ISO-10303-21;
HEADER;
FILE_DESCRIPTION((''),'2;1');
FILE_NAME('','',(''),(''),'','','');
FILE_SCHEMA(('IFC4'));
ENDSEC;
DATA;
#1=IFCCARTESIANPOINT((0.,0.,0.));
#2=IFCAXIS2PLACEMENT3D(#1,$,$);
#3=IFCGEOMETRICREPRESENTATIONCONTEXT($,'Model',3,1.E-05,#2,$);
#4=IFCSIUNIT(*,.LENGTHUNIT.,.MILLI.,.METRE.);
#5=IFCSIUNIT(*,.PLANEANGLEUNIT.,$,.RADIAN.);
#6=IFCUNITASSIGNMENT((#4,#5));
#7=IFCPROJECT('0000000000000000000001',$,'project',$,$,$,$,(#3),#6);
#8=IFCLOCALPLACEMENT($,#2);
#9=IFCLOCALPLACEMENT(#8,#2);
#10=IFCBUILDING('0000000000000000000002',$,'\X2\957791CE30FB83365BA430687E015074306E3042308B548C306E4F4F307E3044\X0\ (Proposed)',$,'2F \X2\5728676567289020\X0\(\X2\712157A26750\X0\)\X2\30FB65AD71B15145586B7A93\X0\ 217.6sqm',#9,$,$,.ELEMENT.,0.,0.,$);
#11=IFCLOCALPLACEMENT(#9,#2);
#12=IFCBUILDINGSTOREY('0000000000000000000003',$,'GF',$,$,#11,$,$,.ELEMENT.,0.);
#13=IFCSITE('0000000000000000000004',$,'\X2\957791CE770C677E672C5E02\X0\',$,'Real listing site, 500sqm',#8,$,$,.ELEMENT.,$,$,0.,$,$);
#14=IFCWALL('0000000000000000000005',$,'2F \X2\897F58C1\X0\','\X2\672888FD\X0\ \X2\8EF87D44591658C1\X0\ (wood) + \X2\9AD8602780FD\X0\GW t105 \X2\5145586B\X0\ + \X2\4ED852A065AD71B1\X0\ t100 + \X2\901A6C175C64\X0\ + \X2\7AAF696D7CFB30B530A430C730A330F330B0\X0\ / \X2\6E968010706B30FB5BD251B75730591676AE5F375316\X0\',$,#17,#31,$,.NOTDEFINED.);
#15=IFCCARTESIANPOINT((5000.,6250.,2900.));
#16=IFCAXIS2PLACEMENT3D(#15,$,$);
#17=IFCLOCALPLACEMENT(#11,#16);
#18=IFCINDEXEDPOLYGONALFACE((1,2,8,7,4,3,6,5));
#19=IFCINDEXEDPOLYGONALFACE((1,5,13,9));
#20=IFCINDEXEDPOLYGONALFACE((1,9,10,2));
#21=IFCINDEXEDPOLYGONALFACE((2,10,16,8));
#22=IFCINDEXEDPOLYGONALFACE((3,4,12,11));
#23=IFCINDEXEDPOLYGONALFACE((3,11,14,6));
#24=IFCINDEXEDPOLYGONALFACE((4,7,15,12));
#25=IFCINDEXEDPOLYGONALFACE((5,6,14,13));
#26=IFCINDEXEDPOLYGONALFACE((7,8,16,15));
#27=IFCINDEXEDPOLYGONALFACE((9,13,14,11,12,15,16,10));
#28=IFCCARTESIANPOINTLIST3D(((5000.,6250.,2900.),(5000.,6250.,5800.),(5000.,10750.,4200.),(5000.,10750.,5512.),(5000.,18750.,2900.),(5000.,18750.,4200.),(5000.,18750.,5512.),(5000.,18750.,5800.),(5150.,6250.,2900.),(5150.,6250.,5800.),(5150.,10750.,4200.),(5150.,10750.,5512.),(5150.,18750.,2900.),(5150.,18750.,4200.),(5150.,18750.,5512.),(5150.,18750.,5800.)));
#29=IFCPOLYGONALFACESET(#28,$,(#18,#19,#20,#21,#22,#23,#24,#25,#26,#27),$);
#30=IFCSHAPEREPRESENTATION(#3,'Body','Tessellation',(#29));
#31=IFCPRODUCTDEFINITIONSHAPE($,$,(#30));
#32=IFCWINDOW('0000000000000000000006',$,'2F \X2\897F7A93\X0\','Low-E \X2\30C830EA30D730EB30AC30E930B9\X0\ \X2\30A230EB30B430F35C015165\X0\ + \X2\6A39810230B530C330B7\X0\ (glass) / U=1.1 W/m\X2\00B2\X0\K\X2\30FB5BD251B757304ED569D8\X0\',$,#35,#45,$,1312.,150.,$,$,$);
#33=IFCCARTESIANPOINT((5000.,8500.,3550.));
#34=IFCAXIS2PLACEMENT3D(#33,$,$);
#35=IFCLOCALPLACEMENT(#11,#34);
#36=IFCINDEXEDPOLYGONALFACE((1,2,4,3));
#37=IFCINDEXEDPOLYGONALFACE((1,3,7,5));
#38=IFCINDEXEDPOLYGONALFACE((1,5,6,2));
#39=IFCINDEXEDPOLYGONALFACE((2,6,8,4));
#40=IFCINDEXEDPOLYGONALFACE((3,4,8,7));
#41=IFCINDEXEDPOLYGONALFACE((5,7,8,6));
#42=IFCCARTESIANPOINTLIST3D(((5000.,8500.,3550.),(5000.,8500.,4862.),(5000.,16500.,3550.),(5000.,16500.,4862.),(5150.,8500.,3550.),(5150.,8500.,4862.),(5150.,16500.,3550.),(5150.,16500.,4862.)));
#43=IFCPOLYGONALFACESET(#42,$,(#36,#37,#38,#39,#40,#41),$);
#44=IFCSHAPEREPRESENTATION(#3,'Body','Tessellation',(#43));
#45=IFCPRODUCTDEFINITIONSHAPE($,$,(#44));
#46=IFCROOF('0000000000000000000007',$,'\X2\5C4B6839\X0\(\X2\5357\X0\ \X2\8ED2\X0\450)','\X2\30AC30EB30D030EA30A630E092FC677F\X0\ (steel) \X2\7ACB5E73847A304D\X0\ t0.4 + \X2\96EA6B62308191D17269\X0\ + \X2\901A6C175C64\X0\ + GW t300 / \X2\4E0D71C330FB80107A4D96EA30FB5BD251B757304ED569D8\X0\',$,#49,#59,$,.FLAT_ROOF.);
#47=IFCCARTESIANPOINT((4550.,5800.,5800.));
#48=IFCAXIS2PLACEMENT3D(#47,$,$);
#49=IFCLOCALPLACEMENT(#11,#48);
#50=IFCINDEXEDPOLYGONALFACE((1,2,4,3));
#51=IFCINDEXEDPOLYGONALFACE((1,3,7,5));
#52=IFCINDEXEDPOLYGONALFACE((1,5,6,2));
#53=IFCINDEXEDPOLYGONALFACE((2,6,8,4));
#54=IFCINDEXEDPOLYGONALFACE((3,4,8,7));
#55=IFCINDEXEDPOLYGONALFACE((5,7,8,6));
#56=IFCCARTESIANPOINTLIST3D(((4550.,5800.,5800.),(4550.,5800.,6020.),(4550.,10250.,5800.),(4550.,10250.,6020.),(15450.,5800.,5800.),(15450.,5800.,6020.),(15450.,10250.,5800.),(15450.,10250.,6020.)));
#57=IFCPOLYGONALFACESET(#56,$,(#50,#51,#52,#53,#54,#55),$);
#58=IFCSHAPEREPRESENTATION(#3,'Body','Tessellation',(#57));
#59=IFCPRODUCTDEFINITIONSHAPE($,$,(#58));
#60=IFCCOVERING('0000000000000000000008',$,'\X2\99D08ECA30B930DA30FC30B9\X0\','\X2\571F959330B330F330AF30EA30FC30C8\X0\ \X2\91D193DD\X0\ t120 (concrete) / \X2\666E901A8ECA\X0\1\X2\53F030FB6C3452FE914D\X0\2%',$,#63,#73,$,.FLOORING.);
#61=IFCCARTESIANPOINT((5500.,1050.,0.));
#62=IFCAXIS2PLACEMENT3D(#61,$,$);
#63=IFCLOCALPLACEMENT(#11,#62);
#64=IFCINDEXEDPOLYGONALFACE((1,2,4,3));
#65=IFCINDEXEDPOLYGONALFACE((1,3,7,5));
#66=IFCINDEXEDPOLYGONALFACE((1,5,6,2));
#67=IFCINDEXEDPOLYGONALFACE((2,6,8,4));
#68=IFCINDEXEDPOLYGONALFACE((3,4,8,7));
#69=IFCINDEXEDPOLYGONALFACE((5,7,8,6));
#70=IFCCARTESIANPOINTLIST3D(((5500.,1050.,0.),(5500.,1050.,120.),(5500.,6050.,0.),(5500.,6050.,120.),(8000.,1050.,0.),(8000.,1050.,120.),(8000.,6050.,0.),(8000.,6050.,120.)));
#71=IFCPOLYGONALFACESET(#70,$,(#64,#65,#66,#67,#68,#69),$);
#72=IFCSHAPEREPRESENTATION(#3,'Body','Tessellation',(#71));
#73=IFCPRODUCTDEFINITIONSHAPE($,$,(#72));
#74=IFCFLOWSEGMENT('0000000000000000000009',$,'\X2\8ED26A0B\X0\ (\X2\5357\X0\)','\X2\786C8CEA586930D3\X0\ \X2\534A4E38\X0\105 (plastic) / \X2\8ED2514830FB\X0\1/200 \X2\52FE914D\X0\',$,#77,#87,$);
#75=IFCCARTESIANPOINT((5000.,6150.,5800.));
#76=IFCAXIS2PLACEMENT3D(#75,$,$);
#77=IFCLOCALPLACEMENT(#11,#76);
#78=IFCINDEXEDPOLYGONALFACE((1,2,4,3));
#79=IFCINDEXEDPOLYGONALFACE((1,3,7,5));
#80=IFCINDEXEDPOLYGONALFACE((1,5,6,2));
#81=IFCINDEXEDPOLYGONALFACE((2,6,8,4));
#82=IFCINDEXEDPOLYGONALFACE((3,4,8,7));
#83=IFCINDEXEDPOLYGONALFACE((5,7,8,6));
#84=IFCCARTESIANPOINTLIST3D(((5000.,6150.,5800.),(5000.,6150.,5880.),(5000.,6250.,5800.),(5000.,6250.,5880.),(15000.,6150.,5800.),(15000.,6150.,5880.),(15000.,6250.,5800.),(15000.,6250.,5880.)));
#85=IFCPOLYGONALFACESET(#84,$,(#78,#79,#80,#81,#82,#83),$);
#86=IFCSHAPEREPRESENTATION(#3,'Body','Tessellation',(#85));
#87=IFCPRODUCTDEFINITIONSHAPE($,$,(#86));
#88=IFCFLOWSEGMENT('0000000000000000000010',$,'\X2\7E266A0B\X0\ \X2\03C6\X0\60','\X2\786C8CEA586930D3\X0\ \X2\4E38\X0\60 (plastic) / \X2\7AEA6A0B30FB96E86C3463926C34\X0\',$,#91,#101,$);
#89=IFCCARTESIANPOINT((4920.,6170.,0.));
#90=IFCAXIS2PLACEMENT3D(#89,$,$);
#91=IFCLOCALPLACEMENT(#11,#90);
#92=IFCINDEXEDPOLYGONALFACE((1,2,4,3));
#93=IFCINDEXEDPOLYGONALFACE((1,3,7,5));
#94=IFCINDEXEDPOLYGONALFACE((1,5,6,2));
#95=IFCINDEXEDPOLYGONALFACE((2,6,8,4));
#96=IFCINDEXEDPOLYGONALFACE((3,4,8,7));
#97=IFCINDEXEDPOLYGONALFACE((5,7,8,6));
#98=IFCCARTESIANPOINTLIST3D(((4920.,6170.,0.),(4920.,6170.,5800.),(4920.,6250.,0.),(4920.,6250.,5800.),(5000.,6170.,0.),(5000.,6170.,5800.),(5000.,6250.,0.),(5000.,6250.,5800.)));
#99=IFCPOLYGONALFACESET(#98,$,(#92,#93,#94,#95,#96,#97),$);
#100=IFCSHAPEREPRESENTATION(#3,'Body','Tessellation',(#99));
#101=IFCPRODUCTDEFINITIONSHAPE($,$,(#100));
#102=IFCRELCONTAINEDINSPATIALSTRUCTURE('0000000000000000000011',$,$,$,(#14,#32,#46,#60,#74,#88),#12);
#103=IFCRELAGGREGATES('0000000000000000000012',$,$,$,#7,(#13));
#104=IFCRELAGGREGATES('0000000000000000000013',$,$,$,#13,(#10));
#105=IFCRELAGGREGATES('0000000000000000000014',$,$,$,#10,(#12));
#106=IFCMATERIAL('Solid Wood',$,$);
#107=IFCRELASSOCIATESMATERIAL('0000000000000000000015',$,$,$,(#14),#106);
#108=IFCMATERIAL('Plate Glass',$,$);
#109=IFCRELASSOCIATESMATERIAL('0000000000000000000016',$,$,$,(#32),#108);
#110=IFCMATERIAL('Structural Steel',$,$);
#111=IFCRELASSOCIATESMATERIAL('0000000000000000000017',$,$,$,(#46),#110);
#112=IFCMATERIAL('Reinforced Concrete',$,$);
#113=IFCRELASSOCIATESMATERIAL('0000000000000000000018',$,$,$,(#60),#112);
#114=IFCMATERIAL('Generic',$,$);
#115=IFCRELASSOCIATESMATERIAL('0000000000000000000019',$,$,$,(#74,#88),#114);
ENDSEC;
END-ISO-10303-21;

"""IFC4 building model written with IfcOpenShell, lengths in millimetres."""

from ifc_helpers import new_model, si_unit, frame, frame_2d, origin, place, context, project, spatial, rectangle, extrude, material, element, fill, save


model = new_model("IFC4")

# Units and contexts
model_context = context("Model", 3, precision=1e-05, world=origin())
ifc_project = project(units=[si_unit("LENGTHUNIT", "METRE", prefix="MILLI"), si_unit("PLANEANGLEUNIT", "RADIAN")], contexts=[model_context])

# Site, building, storey
site_placement = place(None, origin())
site = spatial("IfcSite", under=ifc_project, at=site_placement, Name="長野県松本市", ObjectType="Real listing site, 500sqm", CompositionType="ELEMENT", RefElevation=0.0)
building_placement = place(site_placement, origin())
building = spatial("IfcBuilding", under=site, at=building_placement, Name="長野・茶室と縁側のある和の住まい (Proposed)", ObjectType="2F 在来木造(無垢材)・断熱充填窓 217.6sqm", CompositionType="ELEMENT", ElevationOfRefHeight=0.0, ElevationOfTerrain=0.0)
storey_placement = place(building_placement, origin())
storey = spatial("IfcBuildingStorey", under=building, at=storey_placement, Name="GF", CompositionType="ELEMENT", Elevation=0.0)

# Shared definitions
ifc_material_1 = material(Name="Solid Wood")

# Shared definitions
ifc_material_2 = material(Name="Reinforced Concrete")

# Shared definitions
ifc_material_3 = material(Name="Plate Glass")

# Wall, opening, window
wall_1_placement = place(storey_placement, frame((5000.0, 6250.0, 2900.0)))
wall_1 = element("IfcWall", 1, at=wall_1_placement, inside=storey, material=ifc_material_1, Name="2F 西壁", Description="木製 軸組外壁 (wood) + 高性能GW t105 充填 + 付加断熱 t100 + 通気層 + 窯業系サイディング / 準耐火・寒冷地外皮強化", PredefinedType="NOTDEFINED", context=model_context, shape_type="SweptSolid", body=[
    extrude(rectangle(XDim=150.0, YDim=12500.0, at=frame_2d((75.0, 6250.0))), frame((5000.0, 6250.0, 2900.0)), (0.0, 0.0, 1.0), 2900.0),
])
opening_1_placement = place(storey_placement, frame((5000.0, 8500.0, 3550.0)))
opening_1 = element("IfcOpeningElement", 2, at=opening_1_placement, cuts=wall_1, PredefinedType="NOTDEFINED", context=model_context, shape_type="SweptSolid", body=[
    extrude(rectangle(XDim=150.0, YDim=8000.0, at=frame_2d((75.0, 4000.0))), frame((5000.0, 8500.0, 3550.0)), (0.0, 0.0, 1.0), 1312.0),
])
window_1_placement = place(storey_placement, frame((5000.0, 8500.0, 3550.0)))
window_1 = element("IfcWindow", 3, at=window_1_placement, inside=storey, material=ifc_material_3, Name="2F 西窓", Description="Low-E トリプルガラス アルゴン封入 + 樹脂サッシ (glass) / U=1.1 W/m²K・寒冷地仕様", OverallHeight=1312.0, OverallWidth=150.0, context=model_context, shape_type="SweptSolid", body=[
    extrude(rectangle(XDim=150.0, YDim=8000.0, at=frame_2d((75.0, 4000.0))), frame((5000.0, 8500.0, 3550.0)), (0.0, 0.0, 1.0), 1312.0),
])
fill(opening_1, window_1)

# Roof
ifc_material_4 = material(Name="Structural Steel")
for number, where, name in (
    (4, (4550.0, 5800.0, 5800.0), "屋根(南 軒450)"),
):
    element("IfcRoof", number, at=place(storey_placement, frame(where)), inside=storey, material=ifc_material_4, Name=name, Description="ガルバリウム鋼板 (steel) 立平葺き t0.4 + 雪止め金物 + 通気層 + GW t300 / 不燃・耐積雪・寒冷地仕様", PredefinedType="FLAT_ROOF", context=model_context, shape_type="SweptSolid", body=[
        extrude(rectangle(XDim=10900.0, YDim=4450.0, at=frame_2d((5450.0, 2225.0))), frame((4550.0, 5800.0, 5800.0)), (0.0, 0.0, 1.0), 220.0),
    ])

# Covering
covering_placement = place(storey_placement, frame((5500.0, 1050.0, 0.0)))
element("IfcCovering", 5, at=covering_placement, inside=storey, material=ifc_material_2, Name="駐車スペース", Description="土間コンクリート 金鏝 t120 (concrete) / 普通車1台・水勾配2%", PredefinedType="FLOORING", context=model_context, shape_type="SweptSolid", body=[
    extrude(rectangle(XDim=2500.0, YDim=5000.0, at=frame_2d((1250.0, 2500.0))), frame((5500.0, 1050.0, 0.0)), (0.0, 0.0, 1.0), 120.0),
])

# Flow segments
ifc_material_5 = material(Name="Generic")
flow_segment_1_placement = place(storey_placement, frame((5000.0, 6150.0, 5800.0)))
element("IfcFlowSegment", 6, at=flow_segment_1_placement, inside=storey, material=ifc_material_5, Name="軒樋 (南)", Description="硬質塩ビ 半丸105 (plastic) / 軒先・1/200 勾配", context=model_context, shape_type="SweptSolid", body=[
    extrude(rectangle(XDim=10000.0, YDim=100.0, at=frame_2d((5000.0, 50.0))), frame((5000.0, 6150.0, 5800.0)), (0.0, 0.0, 1.0), 80.0),
])
flow_segment_2_placement = place(storey_placement, frame((4920.0, 6170.0, 0.0)))
element("IfcFlowSegment", 7, at=flow_segment_2_placement, inside=storey, material=ifc_material_5, Name="縦樋 φ60", Description="硬質塩ビ 丸60 (plastic) / 竪樋・雨水排水", context=model_context, shape_type="SweptSolid", body=[
    extrude(rectangle(XDim=80.0, YDim=80.0, at=frame_2d((40.0, 40.0))), frame((4920.0, 6170.0, 0.0)), (0.0, 0.0, 1.0), 5800.0),
])

save(model, "model.ifc")
